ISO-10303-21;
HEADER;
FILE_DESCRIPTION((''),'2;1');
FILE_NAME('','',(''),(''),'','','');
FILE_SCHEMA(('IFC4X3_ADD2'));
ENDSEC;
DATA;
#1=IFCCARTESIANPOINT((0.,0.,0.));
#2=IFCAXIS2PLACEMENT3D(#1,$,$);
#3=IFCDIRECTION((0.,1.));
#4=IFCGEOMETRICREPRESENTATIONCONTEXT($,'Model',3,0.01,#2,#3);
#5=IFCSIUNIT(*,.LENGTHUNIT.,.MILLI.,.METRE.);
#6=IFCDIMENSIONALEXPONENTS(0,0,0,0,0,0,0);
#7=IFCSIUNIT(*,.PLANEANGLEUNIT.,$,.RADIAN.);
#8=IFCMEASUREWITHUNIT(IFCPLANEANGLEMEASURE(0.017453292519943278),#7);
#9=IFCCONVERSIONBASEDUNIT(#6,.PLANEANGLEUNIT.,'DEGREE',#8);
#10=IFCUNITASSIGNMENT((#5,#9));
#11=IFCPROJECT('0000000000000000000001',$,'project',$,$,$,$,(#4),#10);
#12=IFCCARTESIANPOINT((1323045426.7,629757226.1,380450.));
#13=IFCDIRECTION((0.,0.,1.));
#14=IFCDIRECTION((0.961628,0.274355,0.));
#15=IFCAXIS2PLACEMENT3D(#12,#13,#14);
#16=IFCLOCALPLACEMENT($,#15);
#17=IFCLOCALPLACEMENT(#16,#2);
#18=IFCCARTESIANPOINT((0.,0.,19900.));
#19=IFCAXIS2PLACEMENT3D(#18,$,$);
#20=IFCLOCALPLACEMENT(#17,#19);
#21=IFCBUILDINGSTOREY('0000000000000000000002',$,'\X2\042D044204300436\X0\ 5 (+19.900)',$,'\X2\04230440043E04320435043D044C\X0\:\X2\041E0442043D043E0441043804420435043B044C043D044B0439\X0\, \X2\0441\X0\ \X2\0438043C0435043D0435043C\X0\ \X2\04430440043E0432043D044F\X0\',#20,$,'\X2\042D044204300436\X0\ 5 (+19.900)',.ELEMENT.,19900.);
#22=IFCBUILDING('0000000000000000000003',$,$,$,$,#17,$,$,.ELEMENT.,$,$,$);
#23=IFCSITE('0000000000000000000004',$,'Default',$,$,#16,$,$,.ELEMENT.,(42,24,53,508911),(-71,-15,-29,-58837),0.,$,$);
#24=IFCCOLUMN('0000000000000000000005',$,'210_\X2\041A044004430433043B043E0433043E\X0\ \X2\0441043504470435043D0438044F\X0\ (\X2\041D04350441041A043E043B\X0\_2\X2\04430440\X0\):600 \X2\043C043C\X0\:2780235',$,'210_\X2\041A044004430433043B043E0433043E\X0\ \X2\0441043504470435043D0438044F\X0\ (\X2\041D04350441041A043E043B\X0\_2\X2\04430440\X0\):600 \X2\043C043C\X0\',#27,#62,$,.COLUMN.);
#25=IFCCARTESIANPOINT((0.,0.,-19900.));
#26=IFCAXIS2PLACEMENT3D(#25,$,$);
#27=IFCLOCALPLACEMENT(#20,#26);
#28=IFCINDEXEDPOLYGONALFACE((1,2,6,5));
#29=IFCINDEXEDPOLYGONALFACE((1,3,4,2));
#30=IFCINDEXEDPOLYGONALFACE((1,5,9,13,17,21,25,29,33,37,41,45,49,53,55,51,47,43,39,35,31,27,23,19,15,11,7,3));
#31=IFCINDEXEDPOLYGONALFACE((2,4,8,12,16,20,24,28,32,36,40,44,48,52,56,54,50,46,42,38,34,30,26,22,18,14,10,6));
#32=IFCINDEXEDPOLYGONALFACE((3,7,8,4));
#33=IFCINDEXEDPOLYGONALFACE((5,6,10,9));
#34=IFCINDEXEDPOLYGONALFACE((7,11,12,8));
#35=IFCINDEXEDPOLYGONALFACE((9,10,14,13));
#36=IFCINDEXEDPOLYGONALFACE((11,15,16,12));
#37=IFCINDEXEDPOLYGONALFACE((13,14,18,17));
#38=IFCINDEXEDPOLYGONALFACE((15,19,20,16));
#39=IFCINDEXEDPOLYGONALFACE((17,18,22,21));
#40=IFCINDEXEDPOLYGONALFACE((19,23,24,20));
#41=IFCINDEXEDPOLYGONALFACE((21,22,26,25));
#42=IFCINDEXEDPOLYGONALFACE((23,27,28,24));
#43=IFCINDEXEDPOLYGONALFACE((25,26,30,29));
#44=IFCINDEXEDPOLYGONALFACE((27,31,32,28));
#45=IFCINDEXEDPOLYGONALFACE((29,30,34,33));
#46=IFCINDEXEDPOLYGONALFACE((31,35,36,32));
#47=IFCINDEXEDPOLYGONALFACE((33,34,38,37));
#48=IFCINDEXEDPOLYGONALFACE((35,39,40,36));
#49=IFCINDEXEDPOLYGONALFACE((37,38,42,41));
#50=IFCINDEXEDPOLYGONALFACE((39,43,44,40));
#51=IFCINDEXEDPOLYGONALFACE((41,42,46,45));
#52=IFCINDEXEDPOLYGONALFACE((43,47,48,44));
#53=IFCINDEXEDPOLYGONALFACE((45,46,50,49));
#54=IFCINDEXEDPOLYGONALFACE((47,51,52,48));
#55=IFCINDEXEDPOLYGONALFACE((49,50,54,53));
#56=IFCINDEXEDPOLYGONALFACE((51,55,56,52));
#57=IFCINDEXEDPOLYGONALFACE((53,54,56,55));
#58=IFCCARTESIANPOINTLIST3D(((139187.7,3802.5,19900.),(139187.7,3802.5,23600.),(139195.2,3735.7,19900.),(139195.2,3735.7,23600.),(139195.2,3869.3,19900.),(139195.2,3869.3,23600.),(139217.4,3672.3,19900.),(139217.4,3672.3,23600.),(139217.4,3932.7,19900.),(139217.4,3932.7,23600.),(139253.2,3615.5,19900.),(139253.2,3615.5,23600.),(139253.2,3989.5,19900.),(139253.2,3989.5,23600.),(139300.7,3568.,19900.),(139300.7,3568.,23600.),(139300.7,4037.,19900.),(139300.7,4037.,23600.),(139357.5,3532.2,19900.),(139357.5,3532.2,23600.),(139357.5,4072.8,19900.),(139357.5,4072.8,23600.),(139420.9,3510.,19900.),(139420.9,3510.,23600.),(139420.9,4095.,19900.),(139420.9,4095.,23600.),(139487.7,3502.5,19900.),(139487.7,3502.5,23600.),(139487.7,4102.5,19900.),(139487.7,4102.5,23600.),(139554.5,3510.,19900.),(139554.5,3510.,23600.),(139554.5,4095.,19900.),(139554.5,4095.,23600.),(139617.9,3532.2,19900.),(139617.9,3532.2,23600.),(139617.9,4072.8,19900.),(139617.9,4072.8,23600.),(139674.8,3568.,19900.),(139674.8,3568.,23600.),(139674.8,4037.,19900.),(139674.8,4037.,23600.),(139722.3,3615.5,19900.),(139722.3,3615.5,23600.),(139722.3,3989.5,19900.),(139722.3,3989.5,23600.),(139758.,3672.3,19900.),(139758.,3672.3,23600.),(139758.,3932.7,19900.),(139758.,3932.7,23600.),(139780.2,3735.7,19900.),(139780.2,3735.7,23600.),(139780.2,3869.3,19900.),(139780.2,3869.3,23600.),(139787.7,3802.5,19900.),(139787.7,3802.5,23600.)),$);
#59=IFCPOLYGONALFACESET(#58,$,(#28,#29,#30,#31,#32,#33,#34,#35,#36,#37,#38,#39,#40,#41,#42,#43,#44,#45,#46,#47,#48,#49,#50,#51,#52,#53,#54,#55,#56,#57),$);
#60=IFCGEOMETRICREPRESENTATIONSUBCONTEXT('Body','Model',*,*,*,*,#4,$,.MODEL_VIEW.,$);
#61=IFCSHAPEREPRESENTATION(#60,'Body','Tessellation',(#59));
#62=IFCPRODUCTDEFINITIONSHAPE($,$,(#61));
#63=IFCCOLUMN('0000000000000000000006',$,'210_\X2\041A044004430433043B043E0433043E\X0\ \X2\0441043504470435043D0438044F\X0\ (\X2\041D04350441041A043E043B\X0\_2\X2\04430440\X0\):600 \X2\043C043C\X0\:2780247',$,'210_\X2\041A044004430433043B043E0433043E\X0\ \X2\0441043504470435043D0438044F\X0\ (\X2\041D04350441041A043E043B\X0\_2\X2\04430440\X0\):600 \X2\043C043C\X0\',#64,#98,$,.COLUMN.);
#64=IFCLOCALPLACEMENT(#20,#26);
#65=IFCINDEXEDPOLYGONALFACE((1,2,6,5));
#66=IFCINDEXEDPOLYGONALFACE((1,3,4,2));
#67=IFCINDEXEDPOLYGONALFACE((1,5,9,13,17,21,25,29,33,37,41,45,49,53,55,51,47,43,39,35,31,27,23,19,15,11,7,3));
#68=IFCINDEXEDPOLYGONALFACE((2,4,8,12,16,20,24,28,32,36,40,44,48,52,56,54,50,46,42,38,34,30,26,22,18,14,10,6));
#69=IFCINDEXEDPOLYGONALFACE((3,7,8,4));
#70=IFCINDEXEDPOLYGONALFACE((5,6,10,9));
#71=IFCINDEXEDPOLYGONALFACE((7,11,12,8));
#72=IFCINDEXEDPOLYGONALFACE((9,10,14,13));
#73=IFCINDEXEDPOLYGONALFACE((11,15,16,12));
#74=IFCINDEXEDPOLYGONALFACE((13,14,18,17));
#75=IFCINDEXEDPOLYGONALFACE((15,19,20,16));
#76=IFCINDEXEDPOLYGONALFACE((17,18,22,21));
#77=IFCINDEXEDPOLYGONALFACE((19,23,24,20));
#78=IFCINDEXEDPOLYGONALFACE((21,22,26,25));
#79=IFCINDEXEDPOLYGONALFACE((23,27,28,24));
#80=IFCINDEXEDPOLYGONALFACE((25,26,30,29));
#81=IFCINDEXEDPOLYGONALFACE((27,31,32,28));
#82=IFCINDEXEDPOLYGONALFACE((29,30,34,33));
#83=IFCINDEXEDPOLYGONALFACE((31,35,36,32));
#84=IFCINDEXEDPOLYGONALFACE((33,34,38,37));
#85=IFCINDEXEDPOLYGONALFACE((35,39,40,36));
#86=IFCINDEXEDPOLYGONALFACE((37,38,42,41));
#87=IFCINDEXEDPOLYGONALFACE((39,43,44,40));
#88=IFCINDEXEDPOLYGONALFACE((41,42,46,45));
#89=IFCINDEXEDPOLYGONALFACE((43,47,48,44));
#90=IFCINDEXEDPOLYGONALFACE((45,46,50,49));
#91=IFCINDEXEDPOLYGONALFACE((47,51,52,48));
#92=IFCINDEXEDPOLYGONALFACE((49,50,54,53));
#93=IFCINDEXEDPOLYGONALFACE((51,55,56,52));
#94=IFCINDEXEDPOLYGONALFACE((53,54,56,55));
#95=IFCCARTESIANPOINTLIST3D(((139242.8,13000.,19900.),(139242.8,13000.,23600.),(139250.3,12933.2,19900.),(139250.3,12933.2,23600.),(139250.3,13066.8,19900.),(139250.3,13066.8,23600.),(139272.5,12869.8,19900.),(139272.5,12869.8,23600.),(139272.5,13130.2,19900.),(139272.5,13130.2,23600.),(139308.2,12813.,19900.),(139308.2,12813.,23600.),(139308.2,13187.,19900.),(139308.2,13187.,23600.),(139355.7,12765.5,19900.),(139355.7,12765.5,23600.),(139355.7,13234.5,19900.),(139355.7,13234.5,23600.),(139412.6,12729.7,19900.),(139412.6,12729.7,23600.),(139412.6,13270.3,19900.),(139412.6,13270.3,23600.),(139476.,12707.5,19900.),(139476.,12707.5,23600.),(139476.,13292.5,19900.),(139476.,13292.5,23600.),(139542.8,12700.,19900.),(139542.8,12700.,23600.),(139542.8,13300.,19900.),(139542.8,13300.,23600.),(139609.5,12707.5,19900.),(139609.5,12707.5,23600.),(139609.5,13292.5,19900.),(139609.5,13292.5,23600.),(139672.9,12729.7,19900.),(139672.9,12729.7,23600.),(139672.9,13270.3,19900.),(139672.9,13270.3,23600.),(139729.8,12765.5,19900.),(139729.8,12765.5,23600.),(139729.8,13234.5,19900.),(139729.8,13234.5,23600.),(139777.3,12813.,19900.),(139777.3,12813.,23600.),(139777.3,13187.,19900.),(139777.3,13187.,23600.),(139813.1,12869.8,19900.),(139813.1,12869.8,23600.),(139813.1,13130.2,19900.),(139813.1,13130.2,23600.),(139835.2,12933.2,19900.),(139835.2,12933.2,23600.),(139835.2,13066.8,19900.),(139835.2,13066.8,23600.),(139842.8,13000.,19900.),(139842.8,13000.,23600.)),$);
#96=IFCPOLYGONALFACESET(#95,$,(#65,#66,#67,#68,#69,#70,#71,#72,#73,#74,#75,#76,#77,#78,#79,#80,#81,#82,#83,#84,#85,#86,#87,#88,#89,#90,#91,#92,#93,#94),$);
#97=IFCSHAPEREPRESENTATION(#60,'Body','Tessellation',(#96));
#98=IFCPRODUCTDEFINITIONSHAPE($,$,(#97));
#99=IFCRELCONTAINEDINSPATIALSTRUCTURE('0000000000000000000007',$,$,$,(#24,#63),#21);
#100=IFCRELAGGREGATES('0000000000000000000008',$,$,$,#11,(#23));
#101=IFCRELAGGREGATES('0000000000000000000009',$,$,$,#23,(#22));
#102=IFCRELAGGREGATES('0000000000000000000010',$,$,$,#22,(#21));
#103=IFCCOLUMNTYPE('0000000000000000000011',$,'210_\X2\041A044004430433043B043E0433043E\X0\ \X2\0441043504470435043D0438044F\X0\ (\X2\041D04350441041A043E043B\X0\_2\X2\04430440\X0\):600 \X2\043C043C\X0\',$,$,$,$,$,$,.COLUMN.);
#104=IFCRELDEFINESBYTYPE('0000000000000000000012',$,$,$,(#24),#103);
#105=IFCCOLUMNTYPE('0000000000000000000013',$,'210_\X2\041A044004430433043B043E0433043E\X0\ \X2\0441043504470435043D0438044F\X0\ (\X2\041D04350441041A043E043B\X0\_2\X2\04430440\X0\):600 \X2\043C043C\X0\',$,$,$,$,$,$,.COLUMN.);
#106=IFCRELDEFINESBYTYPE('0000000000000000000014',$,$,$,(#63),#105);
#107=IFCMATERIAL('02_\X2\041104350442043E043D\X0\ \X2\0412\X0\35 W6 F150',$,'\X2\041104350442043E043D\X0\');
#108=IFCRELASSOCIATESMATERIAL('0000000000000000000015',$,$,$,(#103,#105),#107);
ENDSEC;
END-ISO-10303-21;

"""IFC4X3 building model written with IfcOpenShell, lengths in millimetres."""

from ifc_helpers import new_model, entity, si_unit, converted_unit, direction, frame, frame_2d, origin, origin_2d_with_axis, place, context, subcontext, project, spatial, circle, extrude, source, transform, mapped, material, material_profile, profile_set, type_object, type_shapes, element, save


model = new_model("IFC4X3")

# Units and contexts
model_context = context("Model", 3, precision=0.01, world=origin(), true_north=direction((0.0, 1.0)))
body_context = subcontext(model_context, "Body", "Model", "MODEL_VIEW")
ifc_project = project(units=[si_unit("LENGTHUNIT", "METRE", prefix="MILLI"), converted_unit("PLANEANGLEUNIT", "DEGREE", entity("IfcPlaneAngleMeasure", 0.017453292519943278), si_unit("PLANEANGLEUNIT", "RADIAN"), dimensions=[0, 0, 0, 0, 0, 0, 0])], contexts=[model_context])

# Site, building, storey
site_placement = place(None, frame((1323045426.7, 629757226.1, 380450.0), z_axis=(0.0, 0.0, 1.0), x_axis=(0.961628, 0.274355, 0.0)))
site = spatial("IfcSite", under=ifc_project, at=site_placement, Name="Default", CompositionType="ELEMENT", RefLatitude=(42, 24, 53, 508911), RefLongitude=(-71, -15, -29, -58837), RefElevation=0.0)
building_placement = place(site_placement, origin())
building = spatial("IfcBuilding", under=site, at=building_placement, CompositionType="ELEMENT")
storey_placement = place(building_placement, frame((0.0, 0.0, 19900.0)))
storey = spatial("IfcBuildingStorey", under=building, at=storey_placement, Name="Этаж 5 (+19.900)", ObjectType="Уровень:Относительный, с именем уровня", LongName="Этаж 5 (+19.900)", CompositionType="ELEMENT", Elevation=19900.0)

# Columns
ifc_material = material(Name="02_Бетон В35 W6 F150", Category="Бетон")
ifc_material_profile = material_profile(ifc_material, circle(Radius=300.0, at=origin_2d_with_axis()), Name="600 мм")
ifc_profile_set = profile_set([ifc_material_profile], Name="600 мм")
column_type_1 = type_object("IfcColumnType", Name="210_Круглого сечения (НесКол_2ур):600 мм", PredefinedType="COLUMN", material=ifc_profile_set)
shared_shape_1 = source(origin(), body_context, "Body", "SweptSolid", [
    extrude(circle(Radius=300.0, at=frame_2d((0.0, 0.0), x_axis=(1.0, 0.0))), frame((139487.7, 3802.5, 19900.0)), (0.0, 0.0, 1.0), 3700.0),
])
type_shapes(column_type_1, [shared_shape_1])
column_1_placement = place(storey_placement, frame((0.0, 0.0, -19900.0)))
element("IfcColumn", 1, at=column_1_placement, inside=storey, type_object=column_type_1, Name="210_Круглого сечения (НесКол_2ур):600 мм:2780235", ObjectType="210_Круглого сечения (НесКол_2ур):600 мм", PredefinedType="COLUMN", context=body_context, shape_type="MappedRepresentation", body=[
    mapped(shared_shape_1, transform((0.0, 0.0, 0.0), scale=1.0)),
])
column_type_2 = type_object("IfcColumnType", Name="210_Круглого сечения (НесКол_2ур):600 мм", PredefinedType="COLUMN", material=ifc_profile_set)
shared_shape_2 = source(origin(), body_context, "Body", "SweptSolid", [
    extrude(circle(Radius=300.0, at=origin_2d_with_axis()), frame((139542.8, 13000.0, 19900.0)), (0.0, 0.0, 1.0), 3700.0),
])
type_shapes(column_type_2, [shared_shape_2])
column_2_placement = place(storey_placement, frame((0.0, 0.0, -19900.0)))
element("IfcColumn", 2, at=column_2_placement, inside=storey, type_object=column_type_2, Name="210_Круглого сечения (НесКол_2ур):600 мм:2780247", ObjectType="210_Круглого сечения (НесКол_2ур):600 мм", PredefinedType="COLUMN", context=body_context, shape_type="MappedRepresentation", body=[
    mapped(shared_shape_2, transform((0.0, 0.0, 0.0), scale=1.0)),
])

save(model, "model.ifc")
